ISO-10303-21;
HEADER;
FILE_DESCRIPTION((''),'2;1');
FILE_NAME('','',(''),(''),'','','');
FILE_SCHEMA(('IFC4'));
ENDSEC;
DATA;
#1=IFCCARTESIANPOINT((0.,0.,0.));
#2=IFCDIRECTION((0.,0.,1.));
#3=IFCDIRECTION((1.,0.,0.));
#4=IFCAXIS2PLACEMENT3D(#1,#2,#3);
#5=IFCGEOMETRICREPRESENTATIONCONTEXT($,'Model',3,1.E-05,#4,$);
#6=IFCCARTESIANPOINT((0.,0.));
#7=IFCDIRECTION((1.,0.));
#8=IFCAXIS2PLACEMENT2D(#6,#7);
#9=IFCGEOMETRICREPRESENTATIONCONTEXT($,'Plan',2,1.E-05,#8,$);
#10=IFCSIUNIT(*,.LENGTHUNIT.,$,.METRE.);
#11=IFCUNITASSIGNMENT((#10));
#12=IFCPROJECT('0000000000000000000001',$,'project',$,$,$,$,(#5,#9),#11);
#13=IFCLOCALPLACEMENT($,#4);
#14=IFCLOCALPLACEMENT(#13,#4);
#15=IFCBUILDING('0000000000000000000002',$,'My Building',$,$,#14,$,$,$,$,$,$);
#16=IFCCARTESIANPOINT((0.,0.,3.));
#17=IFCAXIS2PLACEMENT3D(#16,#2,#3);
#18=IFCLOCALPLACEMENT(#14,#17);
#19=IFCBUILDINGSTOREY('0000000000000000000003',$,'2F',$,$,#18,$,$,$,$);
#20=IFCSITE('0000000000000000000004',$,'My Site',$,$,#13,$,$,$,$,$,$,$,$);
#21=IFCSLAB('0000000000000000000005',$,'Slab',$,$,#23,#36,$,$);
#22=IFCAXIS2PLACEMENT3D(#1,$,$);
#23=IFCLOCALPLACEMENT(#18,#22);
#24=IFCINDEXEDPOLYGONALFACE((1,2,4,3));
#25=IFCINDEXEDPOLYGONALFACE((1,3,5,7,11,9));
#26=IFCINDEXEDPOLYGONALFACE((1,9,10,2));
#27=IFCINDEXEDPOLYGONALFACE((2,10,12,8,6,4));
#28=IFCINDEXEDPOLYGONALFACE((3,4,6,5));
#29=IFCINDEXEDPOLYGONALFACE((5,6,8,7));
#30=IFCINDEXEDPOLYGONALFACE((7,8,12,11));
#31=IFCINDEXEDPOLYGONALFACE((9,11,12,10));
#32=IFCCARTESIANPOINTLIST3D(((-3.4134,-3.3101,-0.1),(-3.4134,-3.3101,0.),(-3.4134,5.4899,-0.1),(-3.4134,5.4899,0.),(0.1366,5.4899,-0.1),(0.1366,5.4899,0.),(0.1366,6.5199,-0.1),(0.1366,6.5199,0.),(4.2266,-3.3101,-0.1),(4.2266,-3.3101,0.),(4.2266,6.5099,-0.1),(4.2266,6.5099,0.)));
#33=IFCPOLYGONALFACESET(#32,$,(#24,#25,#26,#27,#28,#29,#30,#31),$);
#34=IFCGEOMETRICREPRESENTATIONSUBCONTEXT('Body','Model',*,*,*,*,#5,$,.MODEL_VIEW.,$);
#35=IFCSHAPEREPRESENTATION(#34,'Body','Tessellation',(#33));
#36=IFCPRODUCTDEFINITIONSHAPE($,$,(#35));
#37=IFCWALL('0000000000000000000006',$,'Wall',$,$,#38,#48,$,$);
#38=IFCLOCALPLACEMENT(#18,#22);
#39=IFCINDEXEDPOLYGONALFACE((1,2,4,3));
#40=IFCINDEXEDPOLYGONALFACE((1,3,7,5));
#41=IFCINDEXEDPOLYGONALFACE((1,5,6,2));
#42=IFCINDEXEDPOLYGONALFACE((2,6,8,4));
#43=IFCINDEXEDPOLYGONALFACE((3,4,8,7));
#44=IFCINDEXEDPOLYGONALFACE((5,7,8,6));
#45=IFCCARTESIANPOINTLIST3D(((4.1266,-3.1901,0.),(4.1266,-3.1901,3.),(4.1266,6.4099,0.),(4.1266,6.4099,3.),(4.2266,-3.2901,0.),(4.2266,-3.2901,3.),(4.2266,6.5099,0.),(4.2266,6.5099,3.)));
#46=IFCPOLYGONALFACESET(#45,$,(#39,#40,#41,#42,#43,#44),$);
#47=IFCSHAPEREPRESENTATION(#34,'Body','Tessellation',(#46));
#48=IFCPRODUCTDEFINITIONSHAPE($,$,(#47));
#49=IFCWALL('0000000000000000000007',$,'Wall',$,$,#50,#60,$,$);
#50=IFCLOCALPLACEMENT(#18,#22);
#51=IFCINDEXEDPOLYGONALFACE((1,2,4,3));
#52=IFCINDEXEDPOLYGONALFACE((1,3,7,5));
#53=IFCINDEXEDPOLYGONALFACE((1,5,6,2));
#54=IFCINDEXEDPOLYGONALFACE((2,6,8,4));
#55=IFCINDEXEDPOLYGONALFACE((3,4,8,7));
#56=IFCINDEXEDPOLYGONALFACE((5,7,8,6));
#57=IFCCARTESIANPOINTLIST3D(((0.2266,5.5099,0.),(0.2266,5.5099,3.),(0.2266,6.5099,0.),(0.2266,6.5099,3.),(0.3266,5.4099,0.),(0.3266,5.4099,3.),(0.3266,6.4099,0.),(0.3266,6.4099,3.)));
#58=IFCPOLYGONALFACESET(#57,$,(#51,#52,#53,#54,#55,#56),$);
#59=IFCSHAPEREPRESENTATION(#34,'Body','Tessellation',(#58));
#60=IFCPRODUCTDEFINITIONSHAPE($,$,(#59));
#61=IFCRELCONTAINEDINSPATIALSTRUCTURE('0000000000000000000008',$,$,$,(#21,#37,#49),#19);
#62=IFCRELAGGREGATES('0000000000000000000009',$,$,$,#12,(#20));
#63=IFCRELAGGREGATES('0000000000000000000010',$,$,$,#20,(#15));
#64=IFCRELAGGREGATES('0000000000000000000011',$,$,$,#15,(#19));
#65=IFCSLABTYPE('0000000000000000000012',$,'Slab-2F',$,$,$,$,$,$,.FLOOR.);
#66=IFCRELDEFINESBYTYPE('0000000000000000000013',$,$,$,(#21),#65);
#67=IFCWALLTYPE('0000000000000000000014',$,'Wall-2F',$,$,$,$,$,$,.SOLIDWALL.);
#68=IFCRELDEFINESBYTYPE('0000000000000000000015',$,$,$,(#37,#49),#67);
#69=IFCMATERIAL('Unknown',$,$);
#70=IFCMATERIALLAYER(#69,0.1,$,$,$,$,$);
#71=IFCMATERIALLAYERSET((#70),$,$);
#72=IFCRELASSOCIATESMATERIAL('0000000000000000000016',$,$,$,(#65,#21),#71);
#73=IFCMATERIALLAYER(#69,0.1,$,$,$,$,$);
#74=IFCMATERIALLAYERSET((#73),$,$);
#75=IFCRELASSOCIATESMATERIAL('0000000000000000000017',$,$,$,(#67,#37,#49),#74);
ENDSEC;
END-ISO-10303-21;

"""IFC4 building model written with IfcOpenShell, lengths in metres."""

from ifc_helpers import new_model, si_unit, frame, origin_with_axes, origin_2d_with_axis, place, context, subcontext, project, spatial, line, indexed_curve, outline, extrude, material, layer, layer_set, layer_usage, type_object, element, save


model = new_model("IFC4")

# Units and contexts
model_context = context("Model", 3, precision=1e-05, world=origin_with_axes())
plan_context = context("Plan", 2, precision=1e-05, world=origin_2d_with_axis())
body_context_1 = subcontext(model_context, "Body", "Model", "MODEL_VIEW")
ifc_project = project(units=[si_unit("LENGTHUNIT", "METRE")], contexts=[model_context, plan_context])

# Site, building, storey
site_placement = place(None, origin_with_axes())
site = spatial("IfcSite", under=ifc_project, at=site_placement, Name="My Site")
building_placement = place(site_placement, origin_with_axes())
building = spatial("IfcBuilding", under=site, at=building_placement, Name="My Building")
storey_placement = place(building_placement, frame((0.0, 0.0, 3.0), z_axis=(0.0, 0.0, 1.0), x_axis=(1.0, 0.0, 0.0)))
storey = spatial("IfcBuildingStorey", under=building, at=storey_placement, Name="2F")

# Slab
ifc_material = material(Name="Unknown")
ifc_layer_1 = layer(ifc_material, 0.1)
ifc_layer_set_1 = layer_set([ifc_layer_1])
ifc_layer_usage_1 = layer_usage(ifc_layer_set_1, "AXIS3", "POSITIVE", -0.1)
slab_type = type_object("IfcSlabType", Name="Slab-2F", PredefinedType="FLOOR", material=ifc_layer_set_1)
slab_placement = place(storey_placement, frame((4.2266, 6.5099, 0.0), z_axis=(0.0, 0.0, 1.0), x_axis=(1.0, 0.0, 0.0)))
element("IfcSlab", 1, at=slab_placement, inside=storey, type_object=slab_type, material=ifc_layer_usage_1, Name="Slab", context=body_context_1, shape_type="SweptSolid", body=[
    extrude(outline(indexed_curve([(0.0, 0.0), (0.0, -9.82), (-7.64, -9.82), (-7.64, -1.02), (-4.09, -1.02), (-4.09, 0.01), (0.0, 0.0), (0.0, 0.0)])), frame((0.0, 0.0, -0.1), z_axis=(0.0, 0.0, 1.0), x_axis=(1.0, 0.0, 0.0)), (0.0, 0.0, 1.0), 0.1),
])

# Walls
ifc_layer_2 = layer(ifc_material, 0.1)
ifc_layer_set_2 = layer_set([ifc_layer_2])
ifc_layer_usage_2 = layer_usage(ifc_layer_set_2, "AXIS2", "POSITIVE", 0.0)
wall_type = type_object("IfcWallType", Name="Wall-2F", PredefinedType="SOLIDWALL", material=ifc_layer_set_2)
wall_1_placement = place(storey_placement, frame((4.2266, -3.2901, 0.0), z_axis=(0.0, 0.0, 1.0), x_axis=(0.0, 1.0, 0.0)))
element("IfcWall", 2, at=wall_1_placement, inside=storey, type_object=wall_type, material=ifc_layer_usage_2, Name="Wall", context=body_context_1, shape_type="SweptSolid", body=[
    extrude(outline(indexed_curve([(0.0, 0.0), (0.1, 0.1), (9.7, 0.1), (9.8, 0.0)], segments=[line(1, 2, 3, 4, 1)])), origin_with_axes(), (0.0, 0.0, 1.0), 3.0),
])
ifc_layer_usage_3 = layer_usage(ifc_layer_set_2, "AXIS2", "POSITIVE", 0.0)
wall_2_placement = place(storey_placement, frame((0.2266, 6.4099, 0.0), z_axis=(0.0, 0.0, 1.0), x_axis=(0.0, -1.0, 0.0)))
element("IfcWall", 3, at=wall_2_placement, inside=storey, type_object=wall_type, material=ifc_layer_usage_3, Name="Wall", context=body_context_1, shape_type="SweptSolid", body=[
    extrude(outline(indexed_curve([(-0.1, 0.0), (0.0, 0.1), (1.0, 0.1), (0.9, 0.0)], segments=[line(1, 2, 3, 4, 1)])), origin_with_axes(), (0.0, 0.0, 1.0), 3.0),
])

save(model, "model.ifc")
